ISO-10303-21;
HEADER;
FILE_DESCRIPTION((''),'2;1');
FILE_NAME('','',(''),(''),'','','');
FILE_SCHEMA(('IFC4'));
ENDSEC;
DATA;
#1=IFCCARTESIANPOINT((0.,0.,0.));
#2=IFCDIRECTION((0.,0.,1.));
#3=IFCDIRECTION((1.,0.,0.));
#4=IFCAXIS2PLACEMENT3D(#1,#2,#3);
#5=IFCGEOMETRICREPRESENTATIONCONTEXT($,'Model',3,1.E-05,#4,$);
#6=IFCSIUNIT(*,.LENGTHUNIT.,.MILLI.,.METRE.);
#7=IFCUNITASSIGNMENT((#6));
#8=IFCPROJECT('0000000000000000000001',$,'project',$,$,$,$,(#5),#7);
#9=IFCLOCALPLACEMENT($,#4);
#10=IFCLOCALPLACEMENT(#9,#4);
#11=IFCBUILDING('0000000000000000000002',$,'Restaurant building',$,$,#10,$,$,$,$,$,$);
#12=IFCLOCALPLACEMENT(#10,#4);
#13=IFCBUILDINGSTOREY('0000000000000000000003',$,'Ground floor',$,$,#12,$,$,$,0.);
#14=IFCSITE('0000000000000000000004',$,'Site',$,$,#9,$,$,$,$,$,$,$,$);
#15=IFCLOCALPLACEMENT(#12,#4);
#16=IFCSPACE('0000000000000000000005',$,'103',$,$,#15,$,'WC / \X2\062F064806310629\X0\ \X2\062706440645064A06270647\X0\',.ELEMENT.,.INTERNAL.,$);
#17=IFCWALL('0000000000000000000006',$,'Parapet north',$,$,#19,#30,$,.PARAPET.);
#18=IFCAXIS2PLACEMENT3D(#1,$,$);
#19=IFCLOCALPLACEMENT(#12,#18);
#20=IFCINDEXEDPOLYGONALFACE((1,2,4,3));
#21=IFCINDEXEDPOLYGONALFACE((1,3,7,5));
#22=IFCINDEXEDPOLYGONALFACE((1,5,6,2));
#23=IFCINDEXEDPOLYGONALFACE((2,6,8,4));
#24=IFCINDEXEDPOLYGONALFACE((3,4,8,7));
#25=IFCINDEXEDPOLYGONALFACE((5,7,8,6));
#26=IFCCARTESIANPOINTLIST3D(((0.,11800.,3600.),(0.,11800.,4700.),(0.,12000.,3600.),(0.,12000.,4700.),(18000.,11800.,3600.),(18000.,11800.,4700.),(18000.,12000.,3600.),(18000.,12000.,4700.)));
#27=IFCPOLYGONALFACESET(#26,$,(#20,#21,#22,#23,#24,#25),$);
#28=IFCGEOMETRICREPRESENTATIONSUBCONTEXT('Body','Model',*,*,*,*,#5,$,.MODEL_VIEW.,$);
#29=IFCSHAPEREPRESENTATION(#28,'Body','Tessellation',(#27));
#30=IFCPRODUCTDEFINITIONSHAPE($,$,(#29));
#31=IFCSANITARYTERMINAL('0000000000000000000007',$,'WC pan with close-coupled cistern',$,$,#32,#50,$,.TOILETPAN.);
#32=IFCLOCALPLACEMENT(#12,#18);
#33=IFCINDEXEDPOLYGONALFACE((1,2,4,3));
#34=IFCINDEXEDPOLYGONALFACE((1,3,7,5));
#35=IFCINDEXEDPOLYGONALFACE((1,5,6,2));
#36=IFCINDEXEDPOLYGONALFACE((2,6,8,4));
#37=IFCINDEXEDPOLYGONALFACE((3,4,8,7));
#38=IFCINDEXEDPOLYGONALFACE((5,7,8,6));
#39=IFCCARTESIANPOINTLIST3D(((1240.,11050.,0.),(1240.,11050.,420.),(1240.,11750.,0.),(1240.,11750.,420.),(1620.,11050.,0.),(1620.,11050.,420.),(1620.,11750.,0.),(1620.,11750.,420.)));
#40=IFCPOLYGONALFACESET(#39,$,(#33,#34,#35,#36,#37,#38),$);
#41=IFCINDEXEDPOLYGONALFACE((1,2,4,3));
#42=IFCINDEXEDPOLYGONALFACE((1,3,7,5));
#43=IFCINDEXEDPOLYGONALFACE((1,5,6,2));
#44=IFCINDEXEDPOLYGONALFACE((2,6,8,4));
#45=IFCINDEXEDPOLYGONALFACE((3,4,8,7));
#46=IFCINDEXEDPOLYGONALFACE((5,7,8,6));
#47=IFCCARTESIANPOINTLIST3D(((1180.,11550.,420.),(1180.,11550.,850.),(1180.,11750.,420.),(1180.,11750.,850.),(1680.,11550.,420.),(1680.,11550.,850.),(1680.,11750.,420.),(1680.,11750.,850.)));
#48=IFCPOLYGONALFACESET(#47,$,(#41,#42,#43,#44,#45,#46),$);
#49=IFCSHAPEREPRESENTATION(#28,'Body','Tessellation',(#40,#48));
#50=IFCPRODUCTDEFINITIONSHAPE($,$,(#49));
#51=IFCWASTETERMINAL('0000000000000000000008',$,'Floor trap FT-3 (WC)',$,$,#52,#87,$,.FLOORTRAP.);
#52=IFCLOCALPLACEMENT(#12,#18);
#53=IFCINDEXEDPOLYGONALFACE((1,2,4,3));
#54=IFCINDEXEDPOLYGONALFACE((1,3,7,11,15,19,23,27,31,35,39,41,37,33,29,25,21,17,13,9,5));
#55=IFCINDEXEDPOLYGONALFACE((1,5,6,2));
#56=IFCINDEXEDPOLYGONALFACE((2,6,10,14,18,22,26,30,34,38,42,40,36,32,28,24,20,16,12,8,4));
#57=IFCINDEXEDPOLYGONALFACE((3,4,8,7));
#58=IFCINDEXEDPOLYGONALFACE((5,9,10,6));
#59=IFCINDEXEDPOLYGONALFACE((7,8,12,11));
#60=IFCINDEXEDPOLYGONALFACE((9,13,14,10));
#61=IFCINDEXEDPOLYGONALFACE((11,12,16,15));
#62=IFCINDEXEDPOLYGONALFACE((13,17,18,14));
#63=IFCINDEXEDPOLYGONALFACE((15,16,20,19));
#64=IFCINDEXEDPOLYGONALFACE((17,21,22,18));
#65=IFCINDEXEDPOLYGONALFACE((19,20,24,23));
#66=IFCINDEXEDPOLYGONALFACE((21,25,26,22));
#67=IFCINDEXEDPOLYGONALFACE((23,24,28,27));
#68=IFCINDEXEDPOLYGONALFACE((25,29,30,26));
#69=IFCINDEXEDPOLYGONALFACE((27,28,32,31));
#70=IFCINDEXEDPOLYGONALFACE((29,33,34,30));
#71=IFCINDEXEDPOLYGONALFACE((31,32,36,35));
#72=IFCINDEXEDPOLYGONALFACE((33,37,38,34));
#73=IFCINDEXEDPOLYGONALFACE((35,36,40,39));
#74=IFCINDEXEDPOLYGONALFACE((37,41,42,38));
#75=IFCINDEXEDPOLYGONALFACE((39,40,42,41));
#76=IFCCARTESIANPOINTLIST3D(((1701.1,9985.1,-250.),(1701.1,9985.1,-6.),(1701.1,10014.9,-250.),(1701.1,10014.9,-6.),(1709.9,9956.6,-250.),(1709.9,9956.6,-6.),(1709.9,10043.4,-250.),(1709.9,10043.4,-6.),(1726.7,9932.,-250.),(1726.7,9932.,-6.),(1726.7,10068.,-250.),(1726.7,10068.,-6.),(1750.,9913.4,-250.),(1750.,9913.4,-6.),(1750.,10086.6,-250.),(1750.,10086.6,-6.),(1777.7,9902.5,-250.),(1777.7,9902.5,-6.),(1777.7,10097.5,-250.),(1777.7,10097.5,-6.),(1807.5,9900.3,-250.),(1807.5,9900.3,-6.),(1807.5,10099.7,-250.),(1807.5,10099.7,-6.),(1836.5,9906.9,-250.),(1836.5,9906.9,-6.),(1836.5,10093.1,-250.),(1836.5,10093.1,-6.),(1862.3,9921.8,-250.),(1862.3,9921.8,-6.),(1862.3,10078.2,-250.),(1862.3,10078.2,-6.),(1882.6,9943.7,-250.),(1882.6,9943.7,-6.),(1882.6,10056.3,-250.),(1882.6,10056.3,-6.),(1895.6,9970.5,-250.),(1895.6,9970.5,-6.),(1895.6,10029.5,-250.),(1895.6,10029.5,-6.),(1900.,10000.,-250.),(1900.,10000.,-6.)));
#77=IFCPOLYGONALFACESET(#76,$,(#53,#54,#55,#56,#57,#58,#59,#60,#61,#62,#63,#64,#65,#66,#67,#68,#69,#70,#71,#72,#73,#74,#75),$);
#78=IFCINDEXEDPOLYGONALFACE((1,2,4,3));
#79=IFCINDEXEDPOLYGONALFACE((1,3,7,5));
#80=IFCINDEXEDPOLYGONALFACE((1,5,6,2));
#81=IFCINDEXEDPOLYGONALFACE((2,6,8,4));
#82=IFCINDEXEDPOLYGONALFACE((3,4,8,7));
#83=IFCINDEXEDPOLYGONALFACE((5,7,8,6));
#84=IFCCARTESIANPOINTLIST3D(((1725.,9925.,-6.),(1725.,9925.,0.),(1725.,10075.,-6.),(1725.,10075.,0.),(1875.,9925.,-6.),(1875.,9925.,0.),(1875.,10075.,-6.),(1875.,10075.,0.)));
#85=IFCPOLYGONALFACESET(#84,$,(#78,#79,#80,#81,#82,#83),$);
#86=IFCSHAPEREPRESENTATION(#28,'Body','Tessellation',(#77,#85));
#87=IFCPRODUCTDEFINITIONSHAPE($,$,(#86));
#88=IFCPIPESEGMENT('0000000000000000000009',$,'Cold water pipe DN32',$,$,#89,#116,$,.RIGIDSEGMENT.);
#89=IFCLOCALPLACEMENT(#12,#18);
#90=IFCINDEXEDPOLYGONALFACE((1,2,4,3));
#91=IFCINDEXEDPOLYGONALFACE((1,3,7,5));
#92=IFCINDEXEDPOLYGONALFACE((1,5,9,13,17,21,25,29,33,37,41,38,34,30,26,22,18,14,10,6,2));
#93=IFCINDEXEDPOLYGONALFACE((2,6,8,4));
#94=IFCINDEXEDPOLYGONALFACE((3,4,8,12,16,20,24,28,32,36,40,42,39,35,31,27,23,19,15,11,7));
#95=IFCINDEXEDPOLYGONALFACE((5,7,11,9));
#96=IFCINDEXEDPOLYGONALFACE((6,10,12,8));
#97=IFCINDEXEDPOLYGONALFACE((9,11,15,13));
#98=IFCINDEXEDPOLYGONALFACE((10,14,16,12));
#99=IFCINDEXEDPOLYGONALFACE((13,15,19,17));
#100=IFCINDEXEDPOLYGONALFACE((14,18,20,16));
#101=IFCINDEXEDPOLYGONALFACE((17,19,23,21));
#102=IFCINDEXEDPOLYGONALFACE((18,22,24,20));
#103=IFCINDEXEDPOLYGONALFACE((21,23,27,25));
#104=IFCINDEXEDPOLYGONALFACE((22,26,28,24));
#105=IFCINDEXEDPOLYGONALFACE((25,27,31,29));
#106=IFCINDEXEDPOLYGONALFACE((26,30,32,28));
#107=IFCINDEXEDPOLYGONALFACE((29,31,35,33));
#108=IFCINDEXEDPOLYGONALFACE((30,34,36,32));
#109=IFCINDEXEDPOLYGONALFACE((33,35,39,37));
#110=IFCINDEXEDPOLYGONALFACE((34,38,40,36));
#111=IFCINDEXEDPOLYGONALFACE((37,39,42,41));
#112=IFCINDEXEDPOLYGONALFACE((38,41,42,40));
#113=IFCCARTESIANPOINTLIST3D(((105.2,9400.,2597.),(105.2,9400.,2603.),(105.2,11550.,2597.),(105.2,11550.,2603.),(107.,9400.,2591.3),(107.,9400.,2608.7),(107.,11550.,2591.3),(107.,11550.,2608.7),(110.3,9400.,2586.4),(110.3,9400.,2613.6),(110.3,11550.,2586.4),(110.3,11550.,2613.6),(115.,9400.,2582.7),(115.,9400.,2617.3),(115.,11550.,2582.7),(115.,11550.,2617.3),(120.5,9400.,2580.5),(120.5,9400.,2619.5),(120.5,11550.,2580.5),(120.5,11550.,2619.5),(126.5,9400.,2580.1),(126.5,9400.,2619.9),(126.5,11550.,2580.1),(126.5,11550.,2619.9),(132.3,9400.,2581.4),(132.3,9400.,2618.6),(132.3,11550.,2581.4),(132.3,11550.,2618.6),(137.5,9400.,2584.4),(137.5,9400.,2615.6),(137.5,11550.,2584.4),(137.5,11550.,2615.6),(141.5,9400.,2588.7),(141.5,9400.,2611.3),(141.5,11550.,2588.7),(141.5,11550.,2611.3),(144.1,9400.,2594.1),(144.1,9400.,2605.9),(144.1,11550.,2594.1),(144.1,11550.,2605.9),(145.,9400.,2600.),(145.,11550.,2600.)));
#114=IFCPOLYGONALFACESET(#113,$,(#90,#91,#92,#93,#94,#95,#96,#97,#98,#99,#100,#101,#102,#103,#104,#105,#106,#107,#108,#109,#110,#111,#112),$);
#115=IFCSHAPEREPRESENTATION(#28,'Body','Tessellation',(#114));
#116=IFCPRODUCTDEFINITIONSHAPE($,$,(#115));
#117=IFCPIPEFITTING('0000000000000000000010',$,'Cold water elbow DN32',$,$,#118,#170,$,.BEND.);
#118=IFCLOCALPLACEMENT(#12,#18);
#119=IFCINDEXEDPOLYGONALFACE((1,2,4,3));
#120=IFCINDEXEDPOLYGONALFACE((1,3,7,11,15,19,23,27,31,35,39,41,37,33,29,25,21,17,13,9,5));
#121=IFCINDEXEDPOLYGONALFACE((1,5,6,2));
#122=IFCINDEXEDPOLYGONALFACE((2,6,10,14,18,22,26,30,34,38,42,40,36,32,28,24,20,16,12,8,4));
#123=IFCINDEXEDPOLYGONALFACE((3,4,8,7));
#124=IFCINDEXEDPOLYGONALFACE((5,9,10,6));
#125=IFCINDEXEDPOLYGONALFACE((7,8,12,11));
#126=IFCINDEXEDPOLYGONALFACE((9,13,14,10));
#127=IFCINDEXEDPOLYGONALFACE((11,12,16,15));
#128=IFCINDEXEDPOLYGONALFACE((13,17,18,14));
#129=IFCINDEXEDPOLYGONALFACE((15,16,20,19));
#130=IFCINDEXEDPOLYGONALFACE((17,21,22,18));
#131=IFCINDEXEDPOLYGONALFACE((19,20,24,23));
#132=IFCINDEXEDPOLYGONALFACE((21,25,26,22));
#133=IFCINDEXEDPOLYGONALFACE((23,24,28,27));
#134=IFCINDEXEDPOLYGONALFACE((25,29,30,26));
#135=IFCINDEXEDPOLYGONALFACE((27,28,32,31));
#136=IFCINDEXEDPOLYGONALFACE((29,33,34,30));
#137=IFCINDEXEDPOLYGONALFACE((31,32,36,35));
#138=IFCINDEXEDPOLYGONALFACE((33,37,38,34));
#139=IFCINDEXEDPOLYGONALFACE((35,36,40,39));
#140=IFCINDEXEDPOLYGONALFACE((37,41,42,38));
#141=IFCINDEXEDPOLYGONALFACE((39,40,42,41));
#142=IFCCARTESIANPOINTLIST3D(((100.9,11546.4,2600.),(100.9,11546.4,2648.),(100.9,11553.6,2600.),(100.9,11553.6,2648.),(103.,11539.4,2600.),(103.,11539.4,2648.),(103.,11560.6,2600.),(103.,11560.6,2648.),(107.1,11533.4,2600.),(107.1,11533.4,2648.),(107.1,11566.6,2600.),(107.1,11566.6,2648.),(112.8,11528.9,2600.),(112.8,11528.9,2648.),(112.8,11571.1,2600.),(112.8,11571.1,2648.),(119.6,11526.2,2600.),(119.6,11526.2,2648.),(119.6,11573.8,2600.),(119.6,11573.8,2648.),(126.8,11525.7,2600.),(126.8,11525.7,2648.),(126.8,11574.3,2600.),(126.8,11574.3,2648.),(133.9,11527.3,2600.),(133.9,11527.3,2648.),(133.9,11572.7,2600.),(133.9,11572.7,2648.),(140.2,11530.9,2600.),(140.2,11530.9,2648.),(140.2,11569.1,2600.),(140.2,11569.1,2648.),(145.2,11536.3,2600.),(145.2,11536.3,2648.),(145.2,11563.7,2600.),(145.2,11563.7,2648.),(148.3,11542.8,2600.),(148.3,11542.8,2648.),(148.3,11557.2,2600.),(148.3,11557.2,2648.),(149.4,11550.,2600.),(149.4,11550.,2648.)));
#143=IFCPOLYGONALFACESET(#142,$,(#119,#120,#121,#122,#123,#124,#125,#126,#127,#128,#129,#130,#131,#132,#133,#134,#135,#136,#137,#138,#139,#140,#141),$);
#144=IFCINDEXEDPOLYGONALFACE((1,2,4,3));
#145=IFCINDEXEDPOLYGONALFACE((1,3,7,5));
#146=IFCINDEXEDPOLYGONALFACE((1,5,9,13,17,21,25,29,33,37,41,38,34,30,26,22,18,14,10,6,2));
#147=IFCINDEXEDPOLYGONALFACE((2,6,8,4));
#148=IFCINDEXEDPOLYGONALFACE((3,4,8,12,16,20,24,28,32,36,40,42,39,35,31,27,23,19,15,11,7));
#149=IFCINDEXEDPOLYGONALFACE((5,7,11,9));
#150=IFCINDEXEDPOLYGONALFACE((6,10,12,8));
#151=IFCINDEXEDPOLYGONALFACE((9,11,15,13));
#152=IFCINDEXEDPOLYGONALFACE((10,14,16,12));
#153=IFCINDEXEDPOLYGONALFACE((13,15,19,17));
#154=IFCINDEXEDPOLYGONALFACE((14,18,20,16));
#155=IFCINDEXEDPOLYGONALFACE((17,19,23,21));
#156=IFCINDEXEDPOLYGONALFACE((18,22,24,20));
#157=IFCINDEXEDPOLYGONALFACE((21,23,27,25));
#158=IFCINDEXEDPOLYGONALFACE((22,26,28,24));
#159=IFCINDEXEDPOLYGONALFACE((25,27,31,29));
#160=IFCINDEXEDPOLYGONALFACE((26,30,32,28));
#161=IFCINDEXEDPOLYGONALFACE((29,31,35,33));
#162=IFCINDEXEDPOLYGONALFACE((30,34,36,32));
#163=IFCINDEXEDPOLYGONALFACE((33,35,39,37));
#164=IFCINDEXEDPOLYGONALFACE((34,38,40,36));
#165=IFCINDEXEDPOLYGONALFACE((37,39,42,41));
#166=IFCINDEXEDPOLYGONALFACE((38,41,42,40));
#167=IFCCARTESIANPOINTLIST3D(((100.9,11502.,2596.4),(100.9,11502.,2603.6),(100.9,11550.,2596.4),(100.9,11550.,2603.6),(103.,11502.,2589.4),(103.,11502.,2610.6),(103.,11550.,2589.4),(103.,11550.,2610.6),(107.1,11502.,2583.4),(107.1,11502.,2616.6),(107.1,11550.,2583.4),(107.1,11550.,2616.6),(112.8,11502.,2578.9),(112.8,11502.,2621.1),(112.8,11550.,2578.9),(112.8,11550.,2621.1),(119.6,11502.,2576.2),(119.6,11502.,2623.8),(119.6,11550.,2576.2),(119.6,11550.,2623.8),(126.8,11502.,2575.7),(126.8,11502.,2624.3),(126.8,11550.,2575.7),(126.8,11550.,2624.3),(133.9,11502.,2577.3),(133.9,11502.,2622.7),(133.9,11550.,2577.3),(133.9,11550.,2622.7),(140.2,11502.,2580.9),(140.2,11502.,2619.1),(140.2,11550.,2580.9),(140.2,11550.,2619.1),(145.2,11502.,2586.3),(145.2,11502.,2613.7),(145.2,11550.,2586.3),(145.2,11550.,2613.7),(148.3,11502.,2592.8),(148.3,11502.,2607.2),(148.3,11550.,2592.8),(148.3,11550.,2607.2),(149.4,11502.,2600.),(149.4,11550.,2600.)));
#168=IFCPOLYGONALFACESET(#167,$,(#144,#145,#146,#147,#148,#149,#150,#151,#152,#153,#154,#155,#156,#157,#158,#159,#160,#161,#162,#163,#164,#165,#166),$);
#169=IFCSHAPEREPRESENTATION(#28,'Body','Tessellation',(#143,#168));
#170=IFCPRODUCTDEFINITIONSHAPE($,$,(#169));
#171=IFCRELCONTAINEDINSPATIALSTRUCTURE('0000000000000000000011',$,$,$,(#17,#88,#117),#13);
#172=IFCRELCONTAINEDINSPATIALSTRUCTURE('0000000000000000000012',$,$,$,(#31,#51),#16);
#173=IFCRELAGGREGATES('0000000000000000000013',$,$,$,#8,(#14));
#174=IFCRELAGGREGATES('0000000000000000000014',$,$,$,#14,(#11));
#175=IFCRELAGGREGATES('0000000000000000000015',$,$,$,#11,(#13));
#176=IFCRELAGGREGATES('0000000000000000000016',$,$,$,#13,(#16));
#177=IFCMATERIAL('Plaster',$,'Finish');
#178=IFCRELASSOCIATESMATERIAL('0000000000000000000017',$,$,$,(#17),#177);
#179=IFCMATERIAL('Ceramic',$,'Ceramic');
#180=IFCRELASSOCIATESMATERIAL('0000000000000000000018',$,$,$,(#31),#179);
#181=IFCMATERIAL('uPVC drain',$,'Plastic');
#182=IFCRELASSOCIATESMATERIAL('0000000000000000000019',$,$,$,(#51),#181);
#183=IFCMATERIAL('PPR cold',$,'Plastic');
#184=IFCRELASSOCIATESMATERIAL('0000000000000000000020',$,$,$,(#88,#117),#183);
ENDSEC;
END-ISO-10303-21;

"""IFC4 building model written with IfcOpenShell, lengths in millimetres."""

from ifc_helpers import new_model, si_unit, frame, origin, origin_with_axes, origin_2d, place, context, subcontext, project, spatial, rectangle, circle, extrude, material, element, save


model = new_model("IFC4")

# Units and contexts
model_context = context("Model", 3, precision=1e-05, world=origin_with_axes())
body_context = subcontext(model_context, "Body", "Model", "MODEL_VIEW")
ifc_project = project(units=[si_unit("LENGTHUNIT", "METRE", prefix="MILLI")], contexts=[model_context])

# Site, building, storey
site_placement = place(None, origin_with_axes())
site = spatial("IfcSite", under=ifc_project, at=site_placement, Name="Site")
building_placement = place(site_placement, origin_with_axes())
building = spatial("IfcBuilding", under=site, at=building_placement, Name="Restaurant building")
storey_placement = place(building_placement, origin_with_axes())
storey = spatial("IfcBuildingStorey", under=building, at=storey_placement, Name="Ground floor", Elevation=0.0)

# Shared definitions
ifc_material_1 = material(Name="Plaster", Category="Finish")

# Wall
wall_1_placement = place(storey_placement, frame((0.0, 11900.0, 0.0)))
element("IfcWall", 1, at=wall_1_placement, inside=storey, material=ifc_material_1, Name="Parapet north", PredefinedType="PARAPET", context=body_context, shape_type="SweptSolid", body=[
    extrude(rectangle(XDim=18000.0, YDim=200.0, at=origin_2d()), frame((9000.0, 0.0, 3600.0)), (0.0, 0.0, 1.0), 1100.0),
])

# Shared definitions
space_placement = place(storey_placement, origin_with_axes())
space = spatial("IfcSpace", under=storey, at=space_placement, Name="103", LongName="WC / دورة المياه", CompositionType="ELEMENT", PredefinedType="INTERNAL")

# Sanitary terminal
ifc_material_2 = material(Name="Ceramic", Category="Ceramic")
sanitary_terminal_placement = place(storey_placement, frame((1240.0, 11050.0, 0.0)))
element("IfcSanitaryTerminal", 2, at=sanitary_terminal_placement, inside=space, material=ifc_material_2, Name="WC pan with close-coupled cistern", PredefinedType="TOILETPAN", context=body_context, shape_type="SweptSolid", body=[
    extrude(rectangle(XDim=380.0, YDim=700.0, at=origin_2d()), frame((190.0, 350.0, 0.0)), (0.0, 0.0, 1.0), 420.0),
    extrude(rectangle(XDim=500.0, YDim=200.0, at=origin_2d()), frame((190.0, 600.0, 420.0)), (0.0, 0.0, 1.0), 430.0),
])

# Waste terminal
ifc_material_3 = material(Name="uPVC drain", Category="Plastic")
waste_terminal_placement = place(storey_placement, frame((1800.0, 10000.0, 0.0)))
element("IfcWasteTerminal", 3, at=waste_terminal_placement, inside=space, material=ifc_material_3, Name="Floor trap FT-3 (WC)", PredefinedType="FLOORTRAP", context=body_context, shape_type="SweptSolid", body=[
    extrude(circle(Radius=100.0, at=origin_2d()), frame((0.0, 0.0, -250.0)), (0.0, 0.0, 1.0), 244.0),
    extrude(rectangle(XDim=150.0, YDim=150.0, at=origin_2d()), frame((0.0, 0.0, -6.0)), (0.0, 0.0, 1.0), 6.0),
])

# Pipe segment
ifc_material_4 = material(Name="PPR cold", Category="Plastic")
pipe_segment_1_placement = place(storey_placement, frame((125.0, 11550.0, 2600.0)))
element("IfcPipeSegment", 4, at=pipe_segment_1_placement, inside=storey, material=ifc_material_4, Name="Cold water pipe DN32", PredefinedType="RIGIDSEGMENT", context=body_context, shape_type="SweptSolid", body=[
    extrude(circle(Radius=20.0, at=origin_2d()), frame((0.0, 0.0, 0.0), z_axis=(0.0, -1.0, 0.0), x_axis=(1.0, 0.0, 0.0)), (0.0, 0.0, 1.0), 2150.0),
])

# Pipe fitting
pipe_fitting_1_placement = place(storey_placement, frame((125.0, 11550.0, 2600.0)))
element("IfcPipeFitting", 5, at=pipe_fitting_1_placement, inside=storey, material=ifc_material_4, Name="Cold water elbow DN32", PredefinedType="BEND", context=body_context, shape_type="SweptSolid", body=[
    extrude(circle(Radius=24.4, at=origin_2d()), origin(), (0.0, 0.0, 1.0), 48.0),
    extrude(circle(Radius=24.4, at=origin_2d()), frame((0.0, 0.0, 0.0), z_axis=(0.0, -1.0, 0.0), x_axis=(1.0, 0.0, 0.0)), (0.0, 0.0, 1.0), 48.0),
])

save(model, "model.ifc")
